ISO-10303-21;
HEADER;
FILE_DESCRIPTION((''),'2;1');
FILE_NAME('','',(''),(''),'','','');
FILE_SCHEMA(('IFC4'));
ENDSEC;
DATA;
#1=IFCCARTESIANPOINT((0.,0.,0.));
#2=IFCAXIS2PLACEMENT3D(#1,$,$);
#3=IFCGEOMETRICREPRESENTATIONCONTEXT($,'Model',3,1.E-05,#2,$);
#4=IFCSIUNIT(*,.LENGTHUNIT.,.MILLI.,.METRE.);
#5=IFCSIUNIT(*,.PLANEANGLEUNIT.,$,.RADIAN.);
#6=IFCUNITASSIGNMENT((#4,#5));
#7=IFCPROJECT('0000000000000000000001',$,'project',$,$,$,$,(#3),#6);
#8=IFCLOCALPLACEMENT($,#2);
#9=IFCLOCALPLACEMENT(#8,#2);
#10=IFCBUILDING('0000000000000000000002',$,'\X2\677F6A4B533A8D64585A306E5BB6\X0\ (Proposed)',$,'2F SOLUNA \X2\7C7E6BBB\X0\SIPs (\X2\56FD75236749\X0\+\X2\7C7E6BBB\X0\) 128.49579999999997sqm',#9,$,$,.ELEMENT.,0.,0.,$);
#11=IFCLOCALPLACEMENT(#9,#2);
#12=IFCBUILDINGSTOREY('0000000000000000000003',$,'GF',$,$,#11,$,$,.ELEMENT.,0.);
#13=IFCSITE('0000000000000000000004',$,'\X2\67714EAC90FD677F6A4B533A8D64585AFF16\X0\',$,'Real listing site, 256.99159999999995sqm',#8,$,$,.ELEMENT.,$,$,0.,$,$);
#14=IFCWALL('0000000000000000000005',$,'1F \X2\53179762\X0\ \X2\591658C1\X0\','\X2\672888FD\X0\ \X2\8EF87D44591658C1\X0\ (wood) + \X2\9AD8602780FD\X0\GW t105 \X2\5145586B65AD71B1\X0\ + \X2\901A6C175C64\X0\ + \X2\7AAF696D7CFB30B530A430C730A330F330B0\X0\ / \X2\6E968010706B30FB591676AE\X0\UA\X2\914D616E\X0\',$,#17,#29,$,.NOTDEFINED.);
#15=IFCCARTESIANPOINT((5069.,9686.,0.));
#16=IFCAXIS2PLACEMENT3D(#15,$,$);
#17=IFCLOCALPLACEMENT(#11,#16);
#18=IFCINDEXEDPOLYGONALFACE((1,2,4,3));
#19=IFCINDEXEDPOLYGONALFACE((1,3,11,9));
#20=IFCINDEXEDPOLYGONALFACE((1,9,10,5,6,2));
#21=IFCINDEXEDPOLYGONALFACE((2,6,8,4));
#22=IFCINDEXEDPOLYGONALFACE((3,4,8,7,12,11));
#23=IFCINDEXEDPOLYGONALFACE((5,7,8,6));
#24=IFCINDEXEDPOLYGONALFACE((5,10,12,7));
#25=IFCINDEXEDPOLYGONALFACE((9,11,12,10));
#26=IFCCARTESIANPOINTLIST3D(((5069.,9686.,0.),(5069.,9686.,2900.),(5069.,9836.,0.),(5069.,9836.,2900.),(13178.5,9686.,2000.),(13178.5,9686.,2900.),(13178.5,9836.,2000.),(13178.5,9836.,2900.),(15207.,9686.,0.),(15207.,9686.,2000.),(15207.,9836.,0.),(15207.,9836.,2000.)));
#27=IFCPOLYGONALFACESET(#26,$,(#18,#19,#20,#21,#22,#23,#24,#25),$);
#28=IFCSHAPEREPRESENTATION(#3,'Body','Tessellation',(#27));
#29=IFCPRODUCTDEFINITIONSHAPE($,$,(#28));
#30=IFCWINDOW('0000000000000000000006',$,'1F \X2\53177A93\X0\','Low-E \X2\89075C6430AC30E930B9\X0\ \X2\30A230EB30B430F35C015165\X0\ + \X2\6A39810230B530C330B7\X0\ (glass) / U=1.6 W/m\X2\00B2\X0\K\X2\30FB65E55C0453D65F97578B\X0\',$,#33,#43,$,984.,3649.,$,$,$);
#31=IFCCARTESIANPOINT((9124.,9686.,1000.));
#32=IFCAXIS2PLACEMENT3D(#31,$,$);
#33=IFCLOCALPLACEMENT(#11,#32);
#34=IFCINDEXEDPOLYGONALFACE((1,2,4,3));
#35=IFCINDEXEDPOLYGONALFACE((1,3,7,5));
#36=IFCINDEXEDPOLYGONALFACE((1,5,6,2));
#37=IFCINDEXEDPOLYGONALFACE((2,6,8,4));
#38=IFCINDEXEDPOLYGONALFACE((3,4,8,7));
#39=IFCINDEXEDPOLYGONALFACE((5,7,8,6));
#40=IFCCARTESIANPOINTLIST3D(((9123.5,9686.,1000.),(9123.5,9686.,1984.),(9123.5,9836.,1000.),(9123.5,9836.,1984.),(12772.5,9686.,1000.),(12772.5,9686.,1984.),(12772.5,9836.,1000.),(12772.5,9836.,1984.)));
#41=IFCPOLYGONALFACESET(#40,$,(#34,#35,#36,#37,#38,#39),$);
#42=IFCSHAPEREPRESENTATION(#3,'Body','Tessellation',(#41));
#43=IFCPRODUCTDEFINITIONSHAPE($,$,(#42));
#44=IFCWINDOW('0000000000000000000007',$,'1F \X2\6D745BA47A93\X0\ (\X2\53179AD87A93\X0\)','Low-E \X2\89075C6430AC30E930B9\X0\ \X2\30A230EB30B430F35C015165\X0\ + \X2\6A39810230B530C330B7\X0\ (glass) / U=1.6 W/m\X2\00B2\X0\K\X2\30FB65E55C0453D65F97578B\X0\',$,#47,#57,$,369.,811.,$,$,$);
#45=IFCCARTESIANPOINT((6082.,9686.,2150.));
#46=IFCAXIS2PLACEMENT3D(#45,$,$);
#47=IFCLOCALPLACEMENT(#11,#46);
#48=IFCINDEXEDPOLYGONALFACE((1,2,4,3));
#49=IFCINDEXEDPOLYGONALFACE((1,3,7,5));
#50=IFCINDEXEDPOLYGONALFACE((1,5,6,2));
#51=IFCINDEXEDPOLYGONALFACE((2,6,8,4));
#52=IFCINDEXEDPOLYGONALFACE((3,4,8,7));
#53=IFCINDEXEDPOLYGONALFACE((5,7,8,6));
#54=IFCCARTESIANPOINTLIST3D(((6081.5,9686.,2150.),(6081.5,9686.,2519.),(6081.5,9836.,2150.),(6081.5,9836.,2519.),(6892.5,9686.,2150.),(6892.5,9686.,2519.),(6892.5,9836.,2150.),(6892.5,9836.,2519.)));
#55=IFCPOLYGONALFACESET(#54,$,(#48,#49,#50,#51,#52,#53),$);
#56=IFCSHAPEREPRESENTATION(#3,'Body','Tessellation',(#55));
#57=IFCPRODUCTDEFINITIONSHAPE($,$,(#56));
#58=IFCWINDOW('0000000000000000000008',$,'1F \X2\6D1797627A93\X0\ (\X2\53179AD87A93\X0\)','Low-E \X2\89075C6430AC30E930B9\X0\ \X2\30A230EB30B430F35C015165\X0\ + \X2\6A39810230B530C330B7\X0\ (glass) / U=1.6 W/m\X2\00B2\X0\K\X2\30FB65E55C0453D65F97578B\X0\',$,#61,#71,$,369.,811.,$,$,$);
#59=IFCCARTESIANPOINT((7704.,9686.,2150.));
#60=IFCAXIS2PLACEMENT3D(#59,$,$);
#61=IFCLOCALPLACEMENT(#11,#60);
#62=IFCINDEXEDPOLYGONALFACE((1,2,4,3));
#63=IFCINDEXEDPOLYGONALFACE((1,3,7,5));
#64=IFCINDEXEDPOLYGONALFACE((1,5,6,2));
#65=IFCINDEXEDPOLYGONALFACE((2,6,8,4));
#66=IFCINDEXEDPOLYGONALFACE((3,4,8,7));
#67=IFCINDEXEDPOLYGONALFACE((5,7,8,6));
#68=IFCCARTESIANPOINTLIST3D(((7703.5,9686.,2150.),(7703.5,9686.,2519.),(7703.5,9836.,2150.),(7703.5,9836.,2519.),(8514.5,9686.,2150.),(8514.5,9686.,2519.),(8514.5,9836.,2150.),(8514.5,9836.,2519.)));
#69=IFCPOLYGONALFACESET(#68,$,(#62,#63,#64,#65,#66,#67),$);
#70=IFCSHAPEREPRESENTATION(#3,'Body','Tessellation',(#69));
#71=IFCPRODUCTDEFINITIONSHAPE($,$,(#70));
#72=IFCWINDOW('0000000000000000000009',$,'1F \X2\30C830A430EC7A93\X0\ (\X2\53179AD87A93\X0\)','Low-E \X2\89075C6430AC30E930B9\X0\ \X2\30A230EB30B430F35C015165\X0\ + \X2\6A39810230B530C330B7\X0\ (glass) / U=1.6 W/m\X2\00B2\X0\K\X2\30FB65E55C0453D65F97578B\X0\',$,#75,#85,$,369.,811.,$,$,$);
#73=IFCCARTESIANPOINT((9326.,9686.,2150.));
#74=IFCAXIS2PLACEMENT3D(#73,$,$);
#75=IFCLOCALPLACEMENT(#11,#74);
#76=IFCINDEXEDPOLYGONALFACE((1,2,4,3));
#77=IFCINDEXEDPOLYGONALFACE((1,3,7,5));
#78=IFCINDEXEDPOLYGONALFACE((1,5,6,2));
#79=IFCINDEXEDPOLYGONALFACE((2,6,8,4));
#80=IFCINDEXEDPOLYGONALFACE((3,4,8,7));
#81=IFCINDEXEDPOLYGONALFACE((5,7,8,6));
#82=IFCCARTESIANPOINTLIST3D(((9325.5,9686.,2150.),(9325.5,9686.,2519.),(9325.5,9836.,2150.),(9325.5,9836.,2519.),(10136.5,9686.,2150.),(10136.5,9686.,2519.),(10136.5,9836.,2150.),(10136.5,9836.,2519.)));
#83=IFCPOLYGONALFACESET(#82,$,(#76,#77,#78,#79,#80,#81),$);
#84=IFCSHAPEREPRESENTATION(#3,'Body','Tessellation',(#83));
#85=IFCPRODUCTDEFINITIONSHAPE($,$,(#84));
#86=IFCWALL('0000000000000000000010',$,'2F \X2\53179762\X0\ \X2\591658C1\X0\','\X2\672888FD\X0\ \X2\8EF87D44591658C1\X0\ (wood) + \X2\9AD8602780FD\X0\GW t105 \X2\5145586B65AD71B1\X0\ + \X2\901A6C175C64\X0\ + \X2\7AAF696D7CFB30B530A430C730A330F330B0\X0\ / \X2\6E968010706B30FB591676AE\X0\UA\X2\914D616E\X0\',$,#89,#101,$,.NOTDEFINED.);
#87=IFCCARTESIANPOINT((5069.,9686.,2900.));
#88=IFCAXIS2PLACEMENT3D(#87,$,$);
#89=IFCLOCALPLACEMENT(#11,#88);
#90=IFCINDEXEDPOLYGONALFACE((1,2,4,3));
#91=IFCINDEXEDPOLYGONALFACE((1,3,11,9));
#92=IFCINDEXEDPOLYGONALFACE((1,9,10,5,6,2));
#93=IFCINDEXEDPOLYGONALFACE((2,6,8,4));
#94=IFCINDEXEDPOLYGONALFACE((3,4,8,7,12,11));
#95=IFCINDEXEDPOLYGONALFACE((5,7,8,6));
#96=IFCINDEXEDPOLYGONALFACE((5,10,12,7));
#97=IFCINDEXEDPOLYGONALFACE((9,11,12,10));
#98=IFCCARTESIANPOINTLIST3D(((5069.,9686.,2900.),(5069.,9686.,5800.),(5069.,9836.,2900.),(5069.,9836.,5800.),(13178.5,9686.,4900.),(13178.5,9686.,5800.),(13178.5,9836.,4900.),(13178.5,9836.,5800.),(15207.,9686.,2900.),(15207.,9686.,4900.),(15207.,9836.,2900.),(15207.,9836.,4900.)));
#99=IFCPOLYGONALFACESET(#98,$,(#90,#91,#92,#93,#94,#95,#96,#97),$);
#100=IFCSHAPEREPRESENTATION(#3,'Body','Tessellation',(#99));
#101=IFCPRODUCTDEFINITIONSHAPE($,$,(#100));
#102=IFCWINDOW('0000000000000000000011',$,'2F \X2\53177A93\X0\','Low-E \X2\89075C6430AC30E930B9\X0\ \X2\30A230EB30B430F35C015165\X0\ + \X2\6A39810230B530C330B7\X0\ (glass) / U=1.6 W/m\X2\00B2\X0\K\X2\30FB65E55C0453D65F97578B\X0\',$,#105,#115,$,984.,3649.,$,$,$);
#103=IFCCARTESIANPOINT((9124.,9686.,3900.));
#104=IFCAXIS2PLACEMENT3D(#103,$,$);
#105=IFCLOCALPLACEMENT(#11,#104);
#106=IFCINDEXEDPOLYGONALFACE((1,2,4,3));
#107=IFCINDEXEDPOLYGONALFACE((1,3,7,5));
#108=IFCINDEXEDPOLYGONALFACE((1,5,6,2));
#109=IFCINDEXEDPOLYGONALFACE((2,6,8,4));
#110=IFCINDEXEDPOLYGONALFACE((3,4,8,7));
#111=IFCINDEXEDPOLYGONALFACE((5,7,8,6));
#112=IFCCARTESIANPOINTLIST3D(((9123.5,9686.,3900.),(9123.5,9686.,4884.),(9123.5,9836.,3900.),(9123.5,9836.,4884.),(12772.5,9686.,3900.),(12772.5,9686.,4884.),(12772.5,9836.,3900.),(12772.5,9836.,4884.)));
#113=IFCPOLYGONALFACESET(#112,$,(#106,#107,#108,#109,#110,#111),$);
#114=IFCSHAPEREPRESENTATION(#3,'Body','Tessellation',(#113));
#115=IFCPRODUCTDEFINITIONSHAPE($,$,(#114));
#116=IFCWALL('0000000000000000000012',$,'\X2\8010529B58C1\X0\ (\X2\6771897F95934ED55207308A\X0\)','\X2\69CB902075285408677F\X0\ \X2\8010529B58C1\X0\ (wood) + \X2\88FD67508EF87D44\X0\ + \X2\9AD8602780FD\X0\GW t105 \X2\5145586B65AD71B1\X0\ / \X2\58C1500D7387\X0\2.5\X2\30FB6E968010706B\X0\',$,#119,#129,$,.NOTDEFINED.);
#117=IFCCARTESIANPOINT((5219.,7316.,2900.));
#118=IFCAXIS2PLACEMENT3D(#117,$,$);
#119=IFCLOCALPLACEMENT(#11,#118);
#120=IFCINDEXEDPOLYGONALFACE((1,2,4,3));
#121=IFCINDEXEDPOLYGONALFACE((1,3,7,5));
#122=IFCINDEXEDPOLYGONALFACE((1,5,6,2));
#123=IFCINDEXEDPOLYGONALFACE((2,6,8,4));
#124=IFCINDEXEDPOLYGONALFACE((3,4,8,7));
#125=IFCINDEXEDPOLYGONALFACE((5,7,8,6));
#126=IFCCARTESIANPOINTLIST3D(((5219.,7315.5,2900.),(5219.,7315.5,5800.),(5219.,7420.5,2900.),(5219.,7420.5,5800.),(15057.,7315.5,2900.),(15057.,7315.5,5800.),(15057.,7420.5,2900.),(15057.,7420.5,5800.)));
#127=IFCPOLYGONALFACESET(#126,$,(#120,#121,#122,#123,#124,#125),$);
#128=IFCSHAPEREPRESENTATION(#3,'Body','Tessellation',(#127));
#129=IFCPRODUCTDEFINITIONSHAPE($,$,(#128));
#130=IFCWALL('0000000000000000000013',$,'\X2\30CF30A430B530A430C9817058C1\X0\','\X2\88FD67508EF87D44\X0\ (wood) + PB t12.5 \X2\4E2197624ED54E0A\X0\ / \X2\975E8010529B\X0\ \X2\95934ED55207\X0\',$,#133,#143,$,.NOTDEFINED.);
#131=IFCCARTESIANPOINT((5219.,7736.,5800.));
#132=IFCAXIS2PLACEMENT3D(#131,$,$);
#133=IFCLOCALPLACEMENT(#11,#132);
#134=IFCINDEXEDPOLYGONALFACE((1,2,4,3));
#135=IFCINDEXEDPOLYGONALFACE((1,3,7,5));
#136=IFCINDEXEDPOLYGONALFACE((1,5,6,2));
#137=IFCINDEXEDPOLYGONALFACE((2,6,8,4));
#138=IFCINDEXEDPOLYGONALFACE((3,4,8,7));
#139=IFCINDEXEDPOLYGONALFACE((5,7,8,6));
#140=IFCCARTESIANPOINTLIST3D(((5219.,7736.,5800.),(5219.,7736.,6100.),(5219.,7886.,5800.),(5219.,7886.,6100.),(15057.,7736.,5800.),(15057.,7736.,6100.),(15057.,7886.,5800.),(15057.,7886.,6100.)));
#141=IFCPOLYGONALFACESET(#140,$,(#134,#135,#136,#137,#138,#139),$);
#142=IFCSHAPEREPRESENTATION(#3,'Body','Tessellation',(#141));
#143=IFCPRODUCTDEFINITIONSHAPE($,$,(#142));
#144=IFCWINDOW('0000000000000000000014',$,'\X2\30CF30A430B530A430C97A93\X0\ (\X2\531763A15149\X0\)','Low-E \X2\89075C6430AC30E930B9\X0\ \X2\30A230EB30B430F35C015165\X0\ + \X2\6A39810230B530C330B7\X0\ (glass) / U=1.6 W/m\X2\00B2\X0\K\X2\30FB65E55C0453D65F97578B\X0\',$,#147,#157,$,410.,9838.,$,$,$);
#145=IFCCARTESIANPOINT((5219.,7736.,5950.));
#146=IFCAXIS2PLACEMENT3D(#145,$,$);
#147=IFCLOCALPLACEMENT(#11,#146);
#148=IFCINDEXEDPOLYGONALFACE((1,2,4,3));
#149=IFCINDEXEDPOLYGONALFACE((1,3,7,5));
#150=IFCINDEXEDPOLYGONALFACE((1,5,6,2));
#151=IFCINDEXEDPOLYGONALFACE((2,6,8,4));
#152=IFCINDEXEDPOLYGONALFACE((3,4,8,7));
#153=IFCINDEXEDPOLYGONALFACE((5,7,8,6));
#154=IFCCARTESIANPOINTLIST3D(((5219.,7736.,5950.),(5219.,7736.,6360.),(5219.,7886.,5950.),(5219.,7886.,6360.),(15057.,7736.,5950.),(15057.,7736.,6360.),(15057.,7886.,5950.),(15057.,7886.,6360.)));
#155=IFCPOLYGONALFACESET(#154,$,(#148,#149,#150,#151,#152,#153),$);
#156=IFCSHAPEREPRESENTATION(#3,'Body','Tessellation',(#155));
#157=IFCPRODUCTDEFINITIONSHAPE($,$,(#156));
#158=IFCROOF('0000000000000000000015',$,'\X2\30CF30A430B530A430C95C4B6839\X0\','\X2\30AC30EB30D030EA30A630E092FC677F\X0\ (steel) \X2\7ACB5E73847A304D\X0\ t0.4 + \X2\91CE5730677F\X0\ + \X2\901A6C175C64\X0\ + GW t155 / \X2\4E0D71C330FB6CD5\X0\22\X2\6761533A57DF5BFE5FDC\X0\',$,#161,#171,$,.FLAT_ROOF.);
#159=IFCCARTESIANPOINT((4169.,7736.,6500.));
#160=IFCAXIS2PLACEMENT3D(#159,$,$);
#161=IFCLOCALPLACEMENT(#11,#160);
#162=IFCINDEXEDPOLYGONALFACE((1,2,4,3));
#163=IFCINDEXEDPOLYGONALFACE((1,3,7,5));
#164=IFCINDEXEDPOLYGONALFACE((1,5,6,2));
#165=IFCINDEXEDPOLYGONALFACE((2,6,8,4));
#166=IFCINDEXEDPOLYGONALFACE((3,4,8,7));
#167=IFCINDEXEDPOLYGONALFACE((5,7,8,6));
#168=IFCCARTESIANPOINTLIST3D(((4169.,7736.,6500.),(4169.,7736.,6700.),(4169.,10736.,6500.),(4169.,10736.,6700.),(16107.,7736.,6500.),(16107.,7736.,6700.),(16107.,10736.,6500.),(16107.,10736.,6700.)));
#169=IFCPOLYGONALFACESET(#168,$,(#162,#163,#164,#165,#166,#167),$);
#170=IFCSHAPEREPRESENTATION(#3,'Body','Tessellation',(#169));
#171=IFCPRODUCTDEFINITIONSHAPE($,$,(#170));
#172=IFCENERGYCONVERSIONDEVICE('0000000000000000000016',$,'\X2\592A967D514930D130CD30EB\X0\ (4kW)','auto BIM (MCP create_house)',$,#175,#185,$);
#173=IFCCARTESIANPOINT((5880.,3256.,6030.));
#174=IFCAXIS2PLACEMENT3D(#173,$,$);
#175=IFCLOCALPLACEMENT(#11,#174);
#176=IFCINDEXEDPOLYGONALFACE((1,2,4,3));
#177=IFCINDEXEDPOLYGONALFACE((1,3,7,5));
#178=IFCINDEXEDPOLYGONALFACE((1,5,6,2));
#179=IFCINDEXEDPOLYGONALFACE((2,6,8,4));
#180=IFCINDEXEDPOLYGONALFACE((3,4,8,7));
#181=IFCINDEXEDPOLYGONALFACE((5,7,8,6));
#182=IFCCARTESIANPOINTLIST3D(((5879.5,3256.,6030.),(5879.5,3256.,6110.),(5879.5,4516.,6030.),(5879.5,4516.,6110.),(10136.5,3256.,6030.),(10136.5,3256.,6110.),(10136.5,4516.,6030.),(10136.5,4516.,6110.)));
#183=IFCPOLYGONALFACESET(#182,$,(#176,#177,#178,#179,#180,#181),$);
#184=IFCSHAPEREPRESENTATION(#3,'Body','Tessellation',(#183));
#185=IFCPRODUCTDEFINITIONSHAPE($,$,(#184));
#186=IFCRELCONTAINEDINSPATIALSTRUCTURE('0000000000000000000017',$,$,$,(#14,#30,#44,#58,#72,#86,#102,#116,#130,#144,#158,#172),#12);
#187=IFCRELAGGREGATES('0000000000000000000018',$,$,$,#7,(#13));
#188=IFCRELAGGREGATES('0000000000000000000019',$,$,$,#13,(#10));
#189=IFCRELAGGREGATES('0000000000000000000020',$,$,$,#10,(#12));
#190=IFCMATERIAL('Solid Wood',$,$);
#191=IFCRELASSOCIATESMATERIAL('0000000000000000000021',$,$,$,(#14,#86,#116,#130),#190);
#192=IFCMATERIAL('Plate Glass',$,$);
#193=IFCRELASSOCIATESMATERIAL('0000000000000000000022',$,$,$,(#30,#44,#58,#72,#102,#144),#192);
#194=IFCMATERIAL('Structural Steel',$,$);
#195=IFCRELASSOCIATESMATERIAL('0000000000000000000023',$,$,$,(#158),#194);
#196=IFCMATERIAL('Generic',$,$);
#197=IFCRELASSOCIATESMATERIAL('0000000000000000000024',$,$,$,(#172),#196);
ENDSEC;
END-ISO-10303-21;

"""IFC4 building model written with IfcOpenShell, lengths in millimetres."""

from ifc_helpers import new_model, si_unit, frame, frame_2d, origin, place, context, project, spatial, rectangle, extrude, material, element, fill, save


model = new_model("IFC4")

# Units and contexts
model_context = context("Model", 3, precision=1e-05, world=origin())
ifc_project = project(units=[si_unit("LENGTHUNIT", "METRE", prefix="MILLI"), si_unit("PLANEANGLEUNIT", "RADIAN")], contexts=[model_context])

# Site, building, storey
site_placement = place(None, origin())
site = spatial("IfcSite", under=ifc_project, at=site_placement, Name="東京都板橋区赤塚６", ObjectType="Real listing site, 256.99159999999995sqm", CompositionType="ELEMENT", RefElevation=0.0)
building_placement = place(site_placement, origin())
building = spatial("IfcBuilding", under=site, at=building_placement, Name="板橋区赤塚の家 (Proposed)", ObjectType="2F SOLUNA 籾殻SIPs (国産杉+籾殻) 128.49579999999997sqm", CompositionType="ELEMENT", ElevationOfRefHeight=0.0, ElevationOfTerrain=0.0)
storey_placement = place(building_placement, origin())
storey = spatial("IfcBuildingStorey", under=building, at=storey_placement, Name="GF", CompositionType="ELEMENT", Elevation=0.0)

# Wall, openings, windows
ifc_material_1 = material(Name="Solid Wood")
wall_1_placement = place(storey_placement, frame((5069.0, 9686.0, 0.0)))
wall_1 = element("IfcWall", 1, at=wall_1_placement, inside=storey, material=ifc_material_1, Name="1F 北面 外壁", Description="木製 軸組外壁 (wood) + 高性能GW t105 充填断熱 + 通気層 + 窯業系サイディング / 準耐火・外皮UA配慮", PredefinedType="NOTDEFINED", context=model_context, shape_type="SweptSolid", body=[
    extrude(rectangle(XDim=10138.0, YDim=150.0, at=frame_2d((5069.0, 75.0))), frame((5069.0, 9686.0, 0.0)), (0.0, 0.0, 1.0), 2900.0),
])
opening_1_placement = place(storey_placement, frame((9124.0, 9686.0, 1000.0)))
opening_1 = element("IfcOpeningElement", 2, at=opening_1_placement, cuts=wall_1, PredefinedType="NOTDEFINED", context=model_context, shape_type="SweptSolid", body=[
    extrude(rectangle(XDim=3649.0, YDim=150.0, at=frame_2d((1824.0, 75.0))), frame((9124.0, 9686.0, 1000.0)), (0.0, 0.0, 1.0), 984.0),
])
opening_2_placement = place(storey_placement, frame((6082.0, 9686.0, 2150.0)))
opening_2 = element("IfcOpeningElement", 3, at=opening_2_placement, cuts=wall_1, PredefinedType="NOTDEFINED", context=model_context, shape_type="SweptSolid", body=[
    extrude(rectangle(XDim=811.0, YDim=150.0, at=frame_2d((405.0, 75.0))), frame((6082.0, 9686.0, 2150.0)), (0.0, 0.0, 1.0), 369.0),
])
opening_3_placement = place(storey_placement, frame((7704.0, 9686.0, 2150.0)))
opening_3 = element("IfcOpeningElement", 4, at=opening_3_placement, cuts=wall_1, PredefinedType="NOTDEFINED", context=model_context, shape_type="SweptSolid", body=[
    extrude(rectangle(XDim=811.0, YDim=150.0, at=frame_2d((405.0, 75.0))), frame((7704.0, 9686.0, 2150.0)), (0.0, 0.0, 1.0), 369.0),
])
opening_4_placement = place(storey_placement, frame((9326.0, 9686.0, 2150.0)))
opening_4 = element("IfcOpeningElement", 5, at=opening_4_placement, cuts=wall_1, PredefinedType="NOTDEFINED", context=model_context, shape_type="SweptSolid", body=[
    extrude(rectangle(XDim=811.0, YDim=150.0, at=frame_2d((405.0, 75.0))), frame((9326.0, 9686.0, 2150.0)), (0.0, 0.0, 1.0), 369.0),
])
ifc_material_2 = material(Name="Plate Glass")
window_1_placement = place(storey_placement, frame((9124.0, 9686.0, 1000.0)))
window_1 = element("IfcWindow", 6, at=window_1_placement, inside=storey, material=ifc_material_2, Name="1F 北窓", Description="Low-E 複層ガラス アルゴン封入 + 樹脂サッシ (glass) / U=1.6 W/m²K・日射取得型", OverallHeight=984.0, OverallWidth=3649.0, context=model_context, shape_type="SweptSolid", body=[
    extrude(rectangle(XDim=3649.0, YDim=150.0, at=frame_2d((1824.0, 75.0))), frame((9124.0, 9686.0, 1000.0)), (0.0, 0.0, 1.0), 984.0),
])
fill(opening_1, window_1)
window_2_placement = place(storey_placement, frame((6082.0, 9686.0, 2150.0)))
window_2 = element("IfcWindow", 7, at=window_2_placement, inside=storey, material=ifc_material_2, Name="1F 浴室窓 (北高窓)", Description="Low-E 複層ガラス アルゴン封入 + 樹脂サッシ (glass) / U=1.6 W/m²K・日射取得型", OverallHeight=369.0, OverallWidth=811.0, context=model_context, shape_type="SweptSolid", body=[
    extrude(rectangle(XDim=811.0, YDim=150.0, at=frame_2d((405.0, 75.0))), frame((6082.0, 9686.0, 2150.0)), (0.0, 0.0, 1.0), 369.0),
])
fill(opening_2, window_2)
window_3_placement = place(storey_placement, frame((7704.0, 9686.0, 2150.0)))
window_3 = element("IfcWindow", 8, at=window_3_placement, inside=storey, material=ifc_material_2, Name="1F 洗面窓 (北高窓)", Description="Low-E 複層ガラス アルゴン封入 + 樹脂サッシ (glass) / U=1.6 W/m²K・日射取得型", OverallHeight=369.0, OverallWidth=811.0, context=model_context, shape_type="SweptSolid", body=[
    extrude(rectangle(XDim=811.0, YDim=150.0, at=frame_2d((405.0, 75.0))), frame((7704.0, 9686.0, 2150.0)), (0.0, 0.0, 1.0), 369.0),
])
fill(opening_3, window_3)
window_4_placement = place(storey_placement, frame((9326.0, 9686.0, 2150.0)))
window_4 = element("IfcWindow", 9, at=window_4_placement, inside=storey, material=ifc_material_2, Name="1F トイレ窓 (北高窓)", Description="Low-E 複層ガラス アルゴン封入 + 樹脂サッシ (glass) / U=1.6 W/m²K・日射取得型", OverallHeight=369.0, OverallWidth=811.0, context=model_context, shape_type="SweptSolid", body=[
    extrude(rectangle(XDim=811.0, YDim=150.0, at=frame_2d((405.0, 75.0))), frame((9326.0, 9686.0, 2150.0)), (0.0, 0.0, 1.0), 369.0),
])
fill(opening_4, window_4)

# Wall, opening, window
wall_2_placement = place(storey_placement, frame((5069.0, 9686.0, 2900.0)))
wall_2 = element("IfcWall", 10, at=wall_2_placement, inside=storey, material=ifc_material_1, Name="2F 北面 外壁", Description="木製 軸組外壁 (wood) + 高性能GW t105 充填断熱 + 通気層 + 窯業系サイディング / 準耐火・外皮UA配慮", PredefinedType="NOTDEFINED", context=model_context, shape_type="SweptSolid", body=[
    extrude(rectangle(XDim=10138.0, YDim=150.0, at=frame_2d((5069.0, 75.0))), frame((5069.0, 9686.0, 2900.0)), (0.0, 0.0, 1.0), 2900.0),
])
opening_5_placement = place(storey_placement, frame((9124.0, 9686.0, 3900.0)))
opening_5 = element("IfcOpeningElement", 11, at=opening_5_placement, cuts=wall_2, PredefinedType="NOTDEFINED", context=model_context, shape_type="SweptSolid", body=[
    extrude(rectangle(XDim=3649.0, YDim=150.0, at=frame_2d((1824.0, 75.0))), frame((9124.0, 9686.0, 3900.0)), (0.0, 0.0, 1.0), 984.0),
])
window_5_placement = place(storey_placement, frame((9124.0, 9686.0, 3900.0)))
window_5 = element("IfcWindow", 12, at=window_5_placement, inside=storey, material=ifc_material_2, Name="2F 北窓", Description="Low-E 複層ガラス アルゴン封入 + 樹脂サッシ (glass) / U=1.6 W/m²K・日射取得型", OverallHeight=984.0, OverallWidth=3649.0, context=model_context, shape_type="SweptSolid", body=[
    extrude(rectangle(XDim=3649.0, YDim=150.0, at=frame_2d((1824.0, 75.0))), frame((9124.0, 9686.0, 3900.0)), (0.0, 0.0, 1.0), 984.0),
])
fill(opening_5, window_5)

# Wall
wall_3_placement = place(storey_placement, frame((5219.0, 7316.0, 2900.0)))
element("IfcWall", 13, at=wall_3_placement, inside=storey, material=ifc_material_1, Name="耐力壁 (東西間仕切り)", Description="構造用合板 耐力壁 (wood) + 製材軸組 + 高性能GW t105 充填断熱 / 壁倍率2.5・準耐火", PredefinedType="NOTDEFINED", context=model_context, shape_type="SweptSolid", body=[
    extrude(rectangle(XDim=9838.0, YDim=105.0, at=frame_2d((4919.0, 52.0))), frame((5219.0, 7316.0, 2900.0)), (0.0, 0.0, 1.0), 2900.0),
])

# Wall, opening, window
wall_4_placement = place(storey_placement, frame((5219.0, 7736.0, 5800.0)))
wall_4 = element("IfcWall", 14, at=wall_4_placement, inside=storey, material=ifc_material_1, Name="ハイサイド腰壁", Description="製材軸組 (wood) + PB t12.5 両面仕上 / 非耐力 間仕切", PredefinedType="NOTDEFINED", context=model_context, shape_type="SweptSolid", body=[
    extrude(rectangle(XDim=9838.0, YDim=150.0, at=frame_2d((4919.0, 75.0))), frame((5219.0, 7736.0, 5800.0)), (0.0, 0.0, 1.0), 700.0),
])
opening_6_placement = place(storey_placement, frame((5219.0, 7736.0, 5950.0)))
opening_6 = element("IfcOpeningElement", 15, at=opening_6_placement, cuts=wall_4, PredefinedType="NOTDEFINED", context=model_context, shape_type="SweptSolid", body=[
    extrude(rectangle(XDim=9838.0, YDim=150.0, at=frame_2d((4919.0, 75.0))), frame((5219.0, 7736.0, 5950.0)), (0.0, 0.0, 1.0), 410.0),
])
window_6_placement = place(storey_placement, frame((5219.0, 7736.0, 5950.0)))
window_6 = element("IfcWindow", 16, at=window_6_placement, inside=storey, material=ifc_material_2, Name="ハイサイド窓 (北採光)", Description="Low-E 複層ガラス アルゴン封入 + 樹脂サッシ (glass) / U=1.6 W/m²K・日射取得型", OverallHeight=410.0, OverallWidth=9838.0, context=model_context, shape_type="SweptSolid", body=[
    extrude(rectangle(XDim=9838.0, YDim=150.0, at=frame_2d((4919.0, 75.0))), frame((5219.0, 7736.0, 5950.0)), (0.0, 0.0, 1.0), 410.0),
])
fill(opening_6, window_6)

# Roof
ifc_material_3 = material(Name="Structural Steel")
roof_placement = place(storey_placement, frame((4169.0, 7736.0, 6500.0)))
element("IfcRoof", 17, at=roof_placement, inside=storey, material=ifc_material_3, Name="ハイサイド屋根", Description="ガルバリウム鋼板 (steel) 立平葺き t0.4 + 野地板 + 通気層 + GW t155 / 不燃・法22条区域対応", PredefinedType="FLAT_ROOF", context=model_context, shape_type="SweptSolid", body=[
    extrude(rectangle(XDim=11938.0, YDim=3000.0, at=frame_2d((5969.0, 1500.0))), frame((4169.0, 7736.0, 6500.0)), (0.0, 0.0, 1.0), 200.0),
])

# Energy conversion device
ifc_material_4 = material(Name="Generic")
energy_conversion_device_placement = place(storey_placement, frame((5880.0, 3256.0, 6030.0)))
element("IfcEnergyConversionDevice", 18, at=energy_conversion_device_placement, inside=storey, material=ifc_material_4, Name="太陽光パネル (4kW)", Description="auto BIM (MCP create_house)", context=model_context, shape_type="SweptSolid", body=[
    extrude(rectangle(XDim=4257.0, YDim=1260.0, at=frame_2d((2128.0, 630.0))), frame((5880.0, 3256.0, 6030.0)), (0.0, 0.0, 1.0), 80.0),
])

save(model, "model.ifc")
